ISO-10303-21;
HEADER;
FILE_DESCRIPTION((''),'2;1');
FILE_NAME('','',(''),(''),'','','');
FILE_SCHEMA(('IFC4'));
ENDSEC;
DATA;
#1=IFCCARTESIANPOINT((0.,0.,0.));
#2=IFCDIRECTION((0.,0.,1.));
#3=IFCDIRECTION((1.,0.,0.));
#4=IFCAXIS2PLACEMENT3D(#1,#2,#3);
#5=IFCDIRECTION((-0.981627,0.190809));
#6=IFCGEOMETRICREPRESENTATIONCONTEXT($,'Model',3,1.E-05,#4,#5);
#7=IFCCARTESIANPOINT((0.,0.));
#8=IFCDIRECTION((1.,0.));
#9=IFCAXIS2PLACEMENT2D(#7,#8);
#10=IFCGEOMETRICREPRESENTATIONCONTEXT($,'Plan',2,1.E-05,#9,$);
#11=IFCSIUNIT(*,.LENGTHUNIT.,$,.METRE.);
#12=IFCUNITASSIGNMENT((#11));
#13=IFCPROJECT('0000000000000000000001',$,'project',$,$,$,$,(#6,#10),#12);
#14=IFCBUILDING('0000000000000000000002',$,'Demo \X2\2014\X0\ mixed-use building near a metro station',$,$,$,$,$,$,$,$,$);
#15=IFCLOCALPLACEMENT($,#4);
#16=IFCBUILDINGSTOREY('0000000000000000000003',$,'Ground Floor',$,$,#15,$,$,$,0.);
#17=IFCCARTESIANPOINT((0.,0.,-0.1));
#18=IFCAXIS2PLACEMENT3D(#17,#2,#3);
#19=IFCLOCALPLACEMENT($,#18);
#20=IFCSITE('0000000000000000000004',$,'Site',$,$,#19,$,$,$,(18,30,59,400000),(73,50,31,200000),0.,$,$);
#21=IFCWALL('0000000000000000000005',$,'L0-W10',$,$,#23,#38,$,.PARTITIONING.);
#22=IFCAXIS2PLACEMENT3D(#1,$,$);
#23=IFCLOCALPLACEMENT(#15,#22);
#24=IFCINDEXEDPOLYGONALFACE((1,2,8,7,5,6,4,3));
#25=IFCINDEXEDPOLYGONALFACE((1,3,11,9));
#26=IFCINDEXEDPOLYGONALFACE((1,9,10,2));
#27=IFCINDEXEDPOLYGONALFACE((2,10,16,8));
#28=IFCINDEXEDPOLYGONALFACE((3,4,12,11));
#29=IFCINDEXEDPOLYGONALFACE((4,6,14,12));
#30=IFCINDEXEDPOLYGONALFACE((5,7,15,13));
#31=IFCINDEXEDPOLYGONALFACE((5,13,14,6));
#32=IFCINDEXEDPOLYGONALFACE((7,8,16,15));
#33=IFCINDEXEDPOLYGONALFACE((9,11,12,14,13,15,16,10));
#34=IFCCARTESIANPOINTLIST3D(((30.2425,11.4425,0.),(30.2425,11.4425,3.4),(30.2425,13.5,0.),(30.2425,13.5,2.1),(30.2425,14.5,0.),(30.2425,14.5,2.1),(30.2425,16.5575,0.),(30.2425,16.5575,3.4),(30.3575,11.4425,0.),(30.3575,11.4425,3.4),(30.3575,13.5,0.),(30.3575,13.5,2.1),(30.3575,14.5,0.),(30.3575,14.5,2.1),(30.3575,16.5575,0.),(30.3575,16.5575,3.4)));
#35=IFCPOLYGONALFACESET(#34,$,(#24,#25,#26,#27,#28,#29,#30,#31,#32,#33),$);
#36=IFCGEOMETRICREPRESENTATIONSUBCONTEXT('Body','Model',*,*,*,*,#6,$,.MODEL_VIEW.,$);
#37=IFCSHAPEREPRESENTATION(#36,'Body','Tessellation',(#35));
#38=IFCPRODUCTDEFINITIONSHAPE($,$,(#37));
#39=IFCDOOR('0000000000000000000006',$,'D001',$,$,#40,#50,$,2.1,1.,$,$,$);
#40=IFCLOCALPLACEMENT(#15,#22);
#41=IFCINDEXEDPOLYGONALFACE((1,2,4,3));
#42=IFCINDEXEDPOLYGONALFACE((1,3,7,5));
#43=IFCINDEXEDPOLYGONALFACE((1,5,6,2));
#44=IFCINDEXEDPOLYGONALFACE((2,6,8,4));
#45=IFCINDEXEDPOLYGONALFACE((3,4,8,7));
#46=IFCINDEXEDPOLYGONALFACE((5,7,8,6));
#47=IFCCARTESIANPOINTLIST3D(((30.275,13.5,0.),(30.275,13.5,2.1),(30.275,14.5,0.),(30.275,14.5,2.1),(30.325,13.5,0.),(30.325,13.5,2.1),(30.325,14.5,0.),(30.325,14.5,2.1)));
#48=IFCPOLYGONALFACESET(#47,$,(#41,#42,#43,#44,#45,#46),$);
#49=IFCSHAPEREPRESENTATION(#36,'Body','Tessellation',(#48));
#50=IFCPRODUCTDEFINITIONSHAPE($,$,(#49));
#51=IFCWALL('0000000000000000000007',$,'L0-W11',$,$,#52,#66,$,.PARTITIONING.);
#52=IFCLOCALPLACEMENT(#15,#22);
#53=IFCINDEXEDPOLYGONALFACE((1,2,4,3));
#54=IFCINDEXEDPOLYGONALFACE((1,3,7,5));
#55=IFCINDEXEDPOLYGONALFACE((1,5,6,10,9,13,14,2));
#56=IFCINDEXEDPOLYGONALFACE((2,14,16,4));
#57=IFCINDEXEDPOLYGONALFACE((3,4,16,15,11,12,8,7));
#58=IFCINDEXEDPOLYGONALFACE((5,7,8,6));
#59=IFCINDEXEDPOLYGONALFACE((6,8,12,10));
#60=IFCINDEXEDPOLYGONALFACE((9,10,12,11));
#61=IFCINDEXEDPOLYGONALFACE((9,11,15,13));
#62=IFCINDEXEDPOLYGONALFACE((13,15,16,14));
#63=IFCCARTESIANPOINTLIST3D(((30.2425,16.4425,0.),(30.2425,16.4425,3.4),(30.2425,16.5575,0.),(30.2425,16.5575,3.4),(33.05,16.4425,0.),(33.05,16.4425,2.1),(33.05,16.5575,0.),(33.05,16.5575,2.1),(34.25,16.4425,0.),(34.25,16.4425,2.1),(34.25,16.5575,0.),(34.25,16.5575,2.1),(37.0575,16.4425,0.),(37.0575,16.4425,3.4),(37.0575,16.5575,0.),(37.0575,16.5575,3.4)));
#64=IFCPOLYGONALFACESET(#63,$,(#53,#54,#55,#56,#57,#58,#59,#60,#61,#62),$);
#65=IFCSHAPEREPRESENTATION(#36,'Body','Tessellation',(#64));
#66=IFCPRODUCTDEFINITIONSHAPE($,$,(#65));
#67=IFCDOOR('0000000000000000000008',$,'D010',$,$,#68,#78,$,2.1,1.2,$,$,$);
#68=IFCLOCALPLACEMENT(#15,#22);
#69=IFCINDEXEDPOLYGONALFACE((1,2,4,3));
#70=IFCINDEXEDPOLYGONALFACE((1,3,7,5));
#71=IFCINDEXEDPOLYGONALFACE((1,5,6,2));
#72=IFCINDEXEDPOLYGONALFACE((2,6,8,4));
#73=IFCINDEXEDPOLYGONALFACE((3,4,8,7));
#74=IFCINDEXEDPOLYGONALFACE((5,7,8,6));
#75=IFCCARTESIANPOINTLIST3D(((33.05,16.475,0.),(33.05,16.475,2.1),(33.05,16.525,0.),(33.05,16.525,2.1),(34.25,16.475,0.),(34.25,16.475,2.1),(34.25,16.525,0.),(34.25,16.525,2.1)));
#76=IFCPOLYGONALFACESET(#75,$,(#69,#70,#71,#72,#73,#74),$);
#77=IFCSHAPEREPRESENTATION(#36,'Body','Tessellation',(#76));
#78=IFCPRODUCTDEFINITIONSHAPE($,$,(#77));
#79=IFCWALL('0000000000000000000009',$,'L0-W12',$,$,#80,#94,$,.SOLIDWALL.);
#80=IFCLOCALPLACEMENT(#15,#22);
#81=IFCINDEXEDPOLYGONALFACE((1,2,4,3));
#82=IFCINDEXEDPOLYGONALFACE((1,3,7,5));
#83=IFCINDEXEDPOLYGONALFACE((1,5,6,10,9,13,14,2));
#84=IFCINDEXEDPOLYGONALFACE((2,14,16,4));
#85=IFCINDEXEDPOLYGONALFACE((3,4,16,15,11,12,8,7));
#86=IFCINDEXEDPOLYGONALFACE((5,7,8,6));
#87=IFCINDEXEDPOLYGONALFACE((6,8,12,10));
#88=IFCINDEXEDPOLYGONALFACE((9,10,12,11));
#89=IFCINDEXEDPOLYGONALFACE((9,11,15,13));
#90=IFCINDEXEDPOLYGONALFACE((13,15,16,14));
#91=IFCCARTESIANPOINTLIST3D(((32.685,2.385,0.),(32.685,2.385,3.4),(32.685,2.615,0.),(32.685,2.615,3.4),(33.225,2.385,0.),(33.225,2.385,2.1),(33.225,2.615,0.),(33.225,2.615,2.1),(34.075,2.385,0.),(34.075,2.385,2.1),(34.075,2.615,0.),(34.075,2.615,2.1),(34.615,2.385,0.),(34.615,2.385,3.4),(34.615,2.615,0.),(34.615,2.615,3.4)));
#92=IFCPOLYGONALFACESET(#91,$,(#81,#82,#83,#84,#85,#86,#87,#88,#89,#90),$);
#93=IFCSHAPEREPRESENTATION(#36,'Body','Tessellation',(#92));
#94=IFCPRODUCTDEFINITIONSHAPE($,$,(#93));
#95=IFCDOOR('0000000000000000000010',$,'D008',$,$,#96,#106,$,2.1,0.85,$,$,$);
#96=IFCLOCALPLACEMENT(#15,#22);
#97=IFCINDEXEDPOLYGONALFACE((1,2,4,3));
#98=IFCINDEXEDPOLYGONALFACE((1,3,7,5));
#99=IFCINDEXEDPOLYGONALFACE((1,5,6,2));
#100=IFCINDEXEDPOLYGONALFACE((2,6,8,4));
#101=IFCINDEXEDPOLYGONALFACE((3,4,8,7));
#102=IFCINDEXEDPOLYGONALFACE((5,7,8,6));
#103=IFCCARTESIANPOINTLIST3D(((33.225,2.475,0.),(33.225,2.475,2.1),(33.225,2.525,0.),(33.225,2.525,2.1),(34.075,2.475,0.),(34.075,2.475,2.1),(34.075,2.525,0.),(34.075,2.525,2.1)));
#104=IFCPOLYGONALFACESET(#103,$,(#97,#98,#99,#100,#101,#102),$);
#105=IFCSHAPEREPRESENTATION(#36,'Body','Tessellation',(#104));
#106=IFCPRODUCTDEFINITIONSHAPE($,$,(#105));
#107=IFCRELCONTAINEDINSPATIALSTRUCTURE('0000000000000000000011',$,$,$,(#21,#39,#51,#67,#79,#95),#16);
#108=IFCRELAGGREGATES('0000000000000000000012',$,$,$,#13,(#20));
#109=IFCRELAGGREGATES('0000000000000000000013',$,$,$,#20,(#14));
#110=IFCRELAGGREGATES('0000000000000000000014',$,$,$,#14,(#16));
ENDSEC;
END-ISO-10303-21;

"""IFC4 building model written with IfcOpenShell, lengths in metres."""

from ifc_helpers import new_model, si_unit, direction, frame, origin_with_axes, origin_2d_with_axis, place, context, subcontext, project, spatial, line, indexed_curve, outline, extrude, element, fill, save


model = new_model("IFC4")

# Units and contexts
model_context = context("Model", 3, precision=1e-05, world=origin_with_axes(), true_north=direction((-0.981627, 0.190809)))
plan_context = context("Plan", 2, precision=1e-05, world=origin_2d_with_axis())
body_context = subcontext(model_context, "Body", "Model", "MODEL_VIEW")
ifc_project = project(units=[si_unit("LENGTHUNIT", "METRE")], contexts=[model_context, plan_context])

# Site, building, storey
site_placement = place(None, frame((0.0, 0.0, -0.1), z_axis=(0.0, 0.0, 1.0), x_axis=(1.0, 0.0, 0.0)))
site = spatial("IfcSite", under=ifc_project, at=site_placement, Name="Site", RefLatitude=(18, 30, 59, 400000), RefLongitude=(73, 50, 31, 200000), RefElevation=0.0)
building = spatial("IfcBuilding", under=site, Name="Demo — mixed-use building near a metro station")
storey_placement = place(None, origin_with_axes())
storey = spatial("IfcBuildingStorey", under=building, at=storey_placement, Name="Ground Floor", Elevation=0.0)

# Walls, openings, doors
wall_1_placement = place(storey_placement, origin_with_axes())
wall_1 = element("IfcWall", 1, at=wall_1_placement, inside=storey, Name="L0-W10", PredefinedType="PARTITIONING", context=body_context, shape_type="SweptSolid", body=[
    extrude(outline(indexed_curve([(30.2425, 11.4425), (30.2425, 16.5575), (30.3575, 16.5575), (30.3575, 11.4425)], segments=[line(1, 2, 3, 4, 1)])), origin_with_axes(), (0.0, 0.0, 1.0), 3.4),
])
opening_1_placement = place(wall_1_placement, origin_with_axes())
opening_1 = element("IfcOpeningElement", 2, at=opening_1_placement, cuts=wall_1, context=body_context, shape_type="SweptSolid", body=[
    extrude(outline(indexed_curve([(30.1925, 13.5), (30.1925, 14.5), (30.4075, 14.5), (30.4075, 13.5)], segments=[line(1, 2, 3, 4, 1)])), origin_with_axes(), (0.0, 0.0, 1.0), 2.1),
])
door_1_placement = place(storey_placement, origin_with_axes())
door_1 = element("IfcDoor", 3, at=door_1_placement, inside=storey, Name="D001", OverallHeight=2.1, OverallWidth=1.0, context=body_context, shape_type="SweptSolid", body=[
    extrude(outline(indexed_curve([(30.275, 13.5), (30.275, 14.5), (30.325, 14.5), (30.325, 13.5)], segments=[line(1, 2, 3, 4, 1)])), origin_with_axes(), (0.0, 0.0, 1.0), 2.1),
])
fill(opening_1, door_1)
wall_2_placement = place(storey_placement, origin_with_axes())
wall_2 = element("IfcWall", 4, at=wall_2_placement, inside=storey, Name="L0-W11", PredefinedType="PARTITIONING", context=body_context, shape_type="SweptSolid", body=[
    extrude(outline(indexed_curve([(37.0575, 16.4425), (30.2425, 16.4425), (30.2425, 16.5575), (37.0575, 16.5575)], segments=[line(1, 2, 3, 4, 1)])), origin_with_axes(), (0.0, 0.0, 1.0), 3.4),
])
opening_2_placement = place(wall_2_placement, origin_with_axes())
opening_2 = element("IfcOpeningElement", 5, at=opening_2_placement, cuts=wall_2, context=body_context, shape_type="SweptSolid", body=[
    extrude(outline(indexed_curve([(34.25, 16.3925), (33.05, 16.3925), (33.05, 16.6075), (34.25, 16.6075)], segments=[line(1, 2, 3, 4, 1)])), origin_with_axes(), (0.0, 0.0, 1.0), 2.1),
])
door_2_placement = place(storey_placement, origin_with_axes())
door_2 = element("IfcDoor", 6, at=door_2_placement, inside=storey, Name="D010", OverallHeight=2.1, OverallWidth=1.2, context=body_context, shape_type="SweptSolid", body=[
    extrude(outline(indexed_curve([(34.25, 16.475), (33.05, 16.475), (33.05, 16.525), (34.25, 16.525)], segments=[line(1, 2, 3, 4, 1)])), origin_with_axes(), (0.0, 0.0, 1.0), 2.1),
])
fill(opening_2, door_2)
wall_3_placement = place(storey_placement, origin_with_axes())
wall_3 = element("IfcWall", 7, at=wall_3_placement, inside=storey, Name="L0-W12", PredefinedType="SOLIDWALL", context=body_context, shape_type="SweptSolid", body=[
    extrude(outline(indexed_curve([(32.685, 2.615), (34.615, 2.615), (34.615, 2.385), (32.685, 2.385)], segments=[line(1, 2, 3, 4, 1)])), origin_with_axes(), (0.0, 0.0, 1.0), 3.4),
])
opening_3_placement = place(wall_3_placement, origin_with_axes())
opening_3 = element("IfcOpeningElement", 8, at=opening_3_placement, cuts=wall_3, context=body_context, shape_type="SweptSolid", body=[
    extrude(outline(indexed_curve([(33.225, 2.665), (34.075, 2.665), (34.075, 2.335), (33.225, 2.335)], segments=[line(1, 2, 3, 4, 1)])), origin_with_axes(), (0.0, 0.0, 1.0), 2.1),
])
door_3_placement = place(storey_placement, origin_with_axes())
door_3 = element("IfcDoor", 9, at=door_3_placement, inside=storey, Name="D008", OverallHeight=2.1, OverallWidth=0.85, context=body_context, shape_type="SweptSolid", body=[
    extrude(outline(indexed_curve([(33.225, 2.525), (34.075, 2.525), (34.075, 2.475), (33.225, 2.475)], segments=[line(1, 2, 3, 4, 1)])), origin_with_axes(), (0.0, 0.0, 1.0), 2.1),
])
fill(opening_3, door_3)

save(model, "model.ifc")
